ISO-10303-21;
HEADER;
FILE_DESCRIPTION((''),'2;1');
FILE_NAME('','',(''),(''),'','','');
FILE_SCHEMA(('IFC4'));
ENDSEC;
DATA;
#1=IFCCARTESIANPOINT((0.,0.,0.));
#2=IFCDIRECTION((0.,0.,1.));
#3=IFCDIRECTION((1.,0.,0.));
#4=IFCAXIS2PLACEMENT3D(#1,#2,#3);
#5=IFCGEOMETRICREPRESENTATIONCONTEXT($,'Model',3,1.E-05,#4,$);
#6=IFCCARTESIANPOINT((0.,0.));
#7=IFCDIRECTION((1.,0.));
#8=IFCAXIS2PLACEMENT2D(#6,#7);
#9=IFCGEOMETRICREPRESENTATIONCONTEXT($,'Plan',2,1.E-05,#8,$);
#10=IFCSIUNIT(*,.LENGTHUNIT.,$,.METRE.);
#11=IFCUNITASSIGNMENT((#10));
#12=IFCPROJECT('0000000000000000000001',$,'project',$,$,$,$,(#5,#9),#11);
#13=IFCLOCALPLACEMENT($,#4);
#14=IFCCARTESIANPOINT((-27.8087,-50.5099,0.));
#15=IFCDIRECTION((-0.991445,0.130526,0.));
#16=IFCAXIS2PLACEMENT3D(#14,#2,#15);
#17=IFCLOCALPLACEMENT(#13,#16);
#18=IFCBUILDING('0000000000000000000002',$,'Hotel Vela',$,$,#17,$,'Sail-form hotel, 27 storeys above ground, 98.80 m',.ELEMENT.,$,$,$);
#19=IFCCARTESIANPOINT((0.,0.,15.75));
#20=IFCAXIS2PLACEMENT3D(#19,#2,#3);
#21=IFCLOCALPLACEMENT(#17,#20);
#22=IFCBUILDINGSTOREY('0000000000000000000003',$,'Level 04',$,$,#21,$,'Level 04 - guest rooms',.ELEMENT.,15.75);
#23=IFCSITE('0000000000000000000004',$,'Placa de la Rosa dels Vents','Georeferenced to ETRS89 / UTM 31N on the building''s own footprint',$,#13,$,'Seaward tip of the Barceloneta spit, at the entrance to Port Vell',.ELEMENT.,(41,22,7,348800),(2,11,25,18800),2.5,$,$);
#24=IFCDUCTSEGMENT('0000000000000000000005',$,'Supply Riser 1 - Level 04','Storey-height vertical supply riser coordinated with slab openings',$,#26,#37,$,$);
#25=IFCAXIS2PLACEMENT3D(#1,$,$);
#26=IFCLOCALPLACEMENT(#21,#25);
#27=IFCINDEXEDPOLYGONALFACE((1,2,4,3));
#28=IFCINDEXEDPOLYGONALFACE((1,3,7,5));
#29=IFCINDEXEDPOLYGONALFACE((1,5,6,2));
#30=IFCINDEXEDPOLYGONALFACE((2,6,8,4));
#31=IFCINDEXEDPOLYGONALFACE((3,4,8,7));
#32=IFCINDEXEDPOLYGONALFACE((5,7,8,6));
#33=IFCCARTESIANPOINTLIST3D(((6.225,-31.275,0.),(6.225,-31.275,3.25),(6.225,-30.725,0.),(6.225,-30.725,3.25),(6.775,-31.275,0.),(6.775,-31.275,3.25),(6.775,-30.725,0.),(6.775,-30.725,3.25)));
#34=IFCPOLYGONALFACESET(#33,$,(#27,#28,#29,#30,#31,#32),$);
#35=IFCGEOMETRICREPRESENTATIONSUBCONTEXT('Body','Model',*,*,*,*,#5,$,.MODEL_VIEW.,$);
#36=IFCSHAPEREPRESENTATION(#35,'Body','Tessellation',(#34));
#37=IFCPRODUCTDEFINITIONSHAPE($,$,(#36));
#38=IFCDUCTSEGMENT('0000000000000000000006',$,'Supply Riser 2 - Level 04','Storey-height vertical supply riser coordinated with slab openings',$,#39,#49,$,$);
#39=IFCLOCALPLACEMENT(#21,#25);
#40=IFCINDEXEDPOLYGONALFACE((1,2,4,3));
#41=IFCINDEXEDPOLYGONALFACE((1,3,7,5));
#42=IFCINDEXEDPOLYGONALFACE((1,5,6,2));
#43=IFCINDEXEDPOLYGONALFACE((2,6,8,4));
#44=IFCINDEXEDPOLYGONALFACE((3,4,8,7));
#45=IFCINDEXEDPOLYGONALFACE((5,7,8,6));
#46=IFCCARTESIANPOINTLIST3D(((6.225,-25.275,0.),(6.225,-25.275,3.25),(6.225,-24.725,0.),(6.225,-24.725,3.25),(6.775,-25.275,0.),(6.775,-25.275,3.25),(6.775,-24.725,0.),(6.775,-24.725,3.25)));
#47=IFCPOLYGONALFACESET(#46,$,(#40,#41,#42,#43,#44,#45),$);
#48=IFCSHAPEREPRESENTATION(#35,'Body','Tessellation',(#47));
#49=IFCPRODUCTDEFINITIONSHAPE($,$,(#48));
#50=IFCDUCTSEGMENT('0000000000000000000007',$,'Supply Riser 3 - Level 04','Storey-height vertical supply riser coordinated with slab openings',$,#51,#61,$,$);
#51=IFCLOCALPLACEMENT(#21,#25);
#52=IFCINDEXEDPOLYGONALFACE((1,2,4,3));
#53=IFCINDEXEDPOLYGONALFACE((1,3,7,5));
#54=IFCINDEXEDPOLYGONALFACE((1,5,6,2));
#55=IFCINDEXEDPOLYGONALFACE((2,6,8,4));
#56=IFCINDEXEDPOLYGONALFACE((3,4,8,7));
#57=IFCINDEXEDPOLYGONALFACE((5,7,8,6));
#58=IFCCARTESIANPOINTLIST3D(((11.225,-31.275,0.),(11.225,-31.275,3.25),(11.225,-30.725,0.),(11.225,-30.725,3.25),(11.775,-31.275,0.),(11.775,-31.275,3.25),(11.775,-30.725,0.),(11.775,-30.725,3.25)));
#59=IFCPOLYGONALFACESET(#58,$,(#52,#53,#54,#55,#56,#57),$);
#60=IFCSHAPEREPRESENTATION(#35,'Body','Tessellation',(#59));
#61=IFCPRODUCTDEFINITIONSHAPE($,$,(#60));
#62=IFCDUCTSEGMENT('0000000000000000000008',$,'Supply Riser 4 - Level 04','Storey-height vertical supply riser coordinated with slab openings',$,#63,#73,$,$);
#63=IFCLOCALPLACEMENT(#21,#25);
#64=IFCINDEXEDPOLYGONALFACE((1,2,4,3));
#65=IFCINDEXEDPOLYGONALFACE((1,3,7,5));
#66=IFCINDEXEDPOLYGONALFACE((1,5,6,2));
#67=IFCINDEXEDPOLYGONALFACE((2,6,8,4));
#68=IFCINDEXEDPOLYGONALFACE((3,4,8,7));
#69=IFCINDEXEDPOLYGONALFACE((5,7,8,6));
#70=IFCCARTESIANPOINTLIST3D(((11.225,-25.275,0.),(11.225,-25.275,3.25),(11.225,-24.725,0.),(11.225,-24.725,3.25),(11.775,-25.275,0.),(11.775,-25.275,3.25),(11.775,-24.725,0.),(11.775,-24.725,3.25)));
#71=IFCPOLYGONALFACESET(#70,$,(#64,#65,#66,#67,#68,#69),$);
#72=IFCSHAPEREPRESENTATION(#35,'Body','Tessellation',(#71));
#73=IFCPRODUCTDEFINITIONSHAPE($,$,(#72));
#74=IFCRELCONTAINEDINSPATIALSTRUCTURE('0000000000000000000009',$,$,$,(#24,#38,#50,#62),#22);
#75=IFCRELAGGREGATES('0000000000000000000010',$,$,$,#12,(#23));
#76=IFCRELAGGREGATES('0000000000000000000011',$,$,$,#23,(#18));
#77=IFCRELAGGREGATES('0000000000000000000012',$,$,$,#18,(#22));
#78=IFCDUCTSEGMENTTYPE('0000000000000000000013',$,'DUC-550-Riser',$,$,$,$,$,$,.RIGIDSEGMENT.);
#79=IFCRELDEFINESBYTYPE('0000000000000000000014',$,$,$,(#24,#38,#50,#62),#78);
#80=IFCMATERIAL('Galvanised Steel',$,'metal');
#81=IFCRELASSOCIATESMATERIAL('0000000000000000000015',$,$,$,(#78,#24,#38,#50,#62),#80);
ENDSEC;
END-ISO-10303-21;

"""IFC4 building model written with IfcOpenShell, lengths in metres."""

from ifc_helpers import new_model, si_unit, frame, origin_with_axes, origin_2d_with_axis, place, context, subcontext, project, spatial, line, indexed_curve, outline, extrude, material, type_object, element, save


model = new_model("IFC4")

# Units and contexts
model_context = context("Model", 3, precision=1e-05, world=origin_with_axes())
plan_context = context("Plan", 2, precision=1e-05, world=origin_2d_with_axis())
body_context = subcontext(model_context, "Body", "Model", "MODEL_VIEW")
ifc_project = project(units=[si_unit("LENGTHUNIT", "METRE")], contexts=[model_context, plan_context])

# Site, building, storey
site_placement = place(None, origin_with_axes())
site = spatial("IfcSite", under=ifc_project, at=site_placement, Name="Placa de la Rosa dels Vents", Description="Georeferenced to ETRS89 / UTM 31N on the building's own footprint", LongName="Seaward tip of the Barceloneta spit, at the entrance to Port Vell", CompositionType="ELEMENT", RefLatitude=(41, 22, 7, 348800), RefLongitude=(2, 11, 25, 18800), RefElevation=2.5)
building_placement = place(site_placement, frame((-27.8087, -50.5099, 0.0), z_axis=(0.0, 0.0, 1.0), x_axis=(-0.991445, 0.130526, 0.0)))
building = spatial("IfcBuilding", under=site, at=building_placement, Name="Hotel Vela", LongName="Sail-form hotel, 27 storeys above ground, 98.80 m", CompositionType="ELEMENT")
storey_placement = place(building_placement, frame((0.0, 0.0, 15.75), z_axis=(0.0, 0.0, 1.0), x_axis=(1.0, 0.0, 0.0)))
storey = spatial("IfcBuildingStorey", under=building, at=storey_placement, Name="Level 04", LongName="Level 04 - guest rooms", CompositionType="ELEMENT", Elevation=15.75)

# Duct segments
ifc_material = material(Name="Galvanised Steel", Category="metal")
duct_segment_type = type_object("IfcDuctSegmentType", Name="DUC-550-Riser", PredefinedType="RIGIDSEGMENT", material=ifc_material)
for number, where, z_axis, x_axis, name in (
    (1, (6.225, -31.275, 0.0), (0.0, 0.0, 1.0), (1.0, 0.0, 0.0), "Supply Riser 1 - Level 04"),
    (2, (6.225, -25.275, 0.0), (0.0, 0.0, 1.0), (1.0, 0.0, 0.0), "Supply Riser 2 - Level 04"),
    (3, (11.225, -31.275, 0.0), (0.0, 0.0, 1.0), (1.0, 0.0, 0.0), "Supply Riser 3 - Level 04"),
    (4, (11.225, -25.275, 0.0), (0.0, 0.0, 1.0), (1.0, 0.0, 0.0), "Supply Riser 4 - Level 04"),
):
    element("IfcDuctSegment", number, at=place(storey_placement, frame(where, z_axis=z_axis, x_axis=x_axis)), inside=storey, type_object=duct_segment_type, material=ifc_material, Name=name, Description="Storey-height vertical supply riser coordinated with slab openings", context=body_context, shape_type="SweptSolid", body=[
        extrude(outline(indexed_curve([(0.0, 0.0), (0.55, 0.0), (0.55, 0.55), (0.0, 0.55)], segments=[line(1, 2, 3, 4, 1)])), origin_with_axes(), (0.0, 0.0, 1.0), 3.25),
    ])

save(model, "model.ifc")
